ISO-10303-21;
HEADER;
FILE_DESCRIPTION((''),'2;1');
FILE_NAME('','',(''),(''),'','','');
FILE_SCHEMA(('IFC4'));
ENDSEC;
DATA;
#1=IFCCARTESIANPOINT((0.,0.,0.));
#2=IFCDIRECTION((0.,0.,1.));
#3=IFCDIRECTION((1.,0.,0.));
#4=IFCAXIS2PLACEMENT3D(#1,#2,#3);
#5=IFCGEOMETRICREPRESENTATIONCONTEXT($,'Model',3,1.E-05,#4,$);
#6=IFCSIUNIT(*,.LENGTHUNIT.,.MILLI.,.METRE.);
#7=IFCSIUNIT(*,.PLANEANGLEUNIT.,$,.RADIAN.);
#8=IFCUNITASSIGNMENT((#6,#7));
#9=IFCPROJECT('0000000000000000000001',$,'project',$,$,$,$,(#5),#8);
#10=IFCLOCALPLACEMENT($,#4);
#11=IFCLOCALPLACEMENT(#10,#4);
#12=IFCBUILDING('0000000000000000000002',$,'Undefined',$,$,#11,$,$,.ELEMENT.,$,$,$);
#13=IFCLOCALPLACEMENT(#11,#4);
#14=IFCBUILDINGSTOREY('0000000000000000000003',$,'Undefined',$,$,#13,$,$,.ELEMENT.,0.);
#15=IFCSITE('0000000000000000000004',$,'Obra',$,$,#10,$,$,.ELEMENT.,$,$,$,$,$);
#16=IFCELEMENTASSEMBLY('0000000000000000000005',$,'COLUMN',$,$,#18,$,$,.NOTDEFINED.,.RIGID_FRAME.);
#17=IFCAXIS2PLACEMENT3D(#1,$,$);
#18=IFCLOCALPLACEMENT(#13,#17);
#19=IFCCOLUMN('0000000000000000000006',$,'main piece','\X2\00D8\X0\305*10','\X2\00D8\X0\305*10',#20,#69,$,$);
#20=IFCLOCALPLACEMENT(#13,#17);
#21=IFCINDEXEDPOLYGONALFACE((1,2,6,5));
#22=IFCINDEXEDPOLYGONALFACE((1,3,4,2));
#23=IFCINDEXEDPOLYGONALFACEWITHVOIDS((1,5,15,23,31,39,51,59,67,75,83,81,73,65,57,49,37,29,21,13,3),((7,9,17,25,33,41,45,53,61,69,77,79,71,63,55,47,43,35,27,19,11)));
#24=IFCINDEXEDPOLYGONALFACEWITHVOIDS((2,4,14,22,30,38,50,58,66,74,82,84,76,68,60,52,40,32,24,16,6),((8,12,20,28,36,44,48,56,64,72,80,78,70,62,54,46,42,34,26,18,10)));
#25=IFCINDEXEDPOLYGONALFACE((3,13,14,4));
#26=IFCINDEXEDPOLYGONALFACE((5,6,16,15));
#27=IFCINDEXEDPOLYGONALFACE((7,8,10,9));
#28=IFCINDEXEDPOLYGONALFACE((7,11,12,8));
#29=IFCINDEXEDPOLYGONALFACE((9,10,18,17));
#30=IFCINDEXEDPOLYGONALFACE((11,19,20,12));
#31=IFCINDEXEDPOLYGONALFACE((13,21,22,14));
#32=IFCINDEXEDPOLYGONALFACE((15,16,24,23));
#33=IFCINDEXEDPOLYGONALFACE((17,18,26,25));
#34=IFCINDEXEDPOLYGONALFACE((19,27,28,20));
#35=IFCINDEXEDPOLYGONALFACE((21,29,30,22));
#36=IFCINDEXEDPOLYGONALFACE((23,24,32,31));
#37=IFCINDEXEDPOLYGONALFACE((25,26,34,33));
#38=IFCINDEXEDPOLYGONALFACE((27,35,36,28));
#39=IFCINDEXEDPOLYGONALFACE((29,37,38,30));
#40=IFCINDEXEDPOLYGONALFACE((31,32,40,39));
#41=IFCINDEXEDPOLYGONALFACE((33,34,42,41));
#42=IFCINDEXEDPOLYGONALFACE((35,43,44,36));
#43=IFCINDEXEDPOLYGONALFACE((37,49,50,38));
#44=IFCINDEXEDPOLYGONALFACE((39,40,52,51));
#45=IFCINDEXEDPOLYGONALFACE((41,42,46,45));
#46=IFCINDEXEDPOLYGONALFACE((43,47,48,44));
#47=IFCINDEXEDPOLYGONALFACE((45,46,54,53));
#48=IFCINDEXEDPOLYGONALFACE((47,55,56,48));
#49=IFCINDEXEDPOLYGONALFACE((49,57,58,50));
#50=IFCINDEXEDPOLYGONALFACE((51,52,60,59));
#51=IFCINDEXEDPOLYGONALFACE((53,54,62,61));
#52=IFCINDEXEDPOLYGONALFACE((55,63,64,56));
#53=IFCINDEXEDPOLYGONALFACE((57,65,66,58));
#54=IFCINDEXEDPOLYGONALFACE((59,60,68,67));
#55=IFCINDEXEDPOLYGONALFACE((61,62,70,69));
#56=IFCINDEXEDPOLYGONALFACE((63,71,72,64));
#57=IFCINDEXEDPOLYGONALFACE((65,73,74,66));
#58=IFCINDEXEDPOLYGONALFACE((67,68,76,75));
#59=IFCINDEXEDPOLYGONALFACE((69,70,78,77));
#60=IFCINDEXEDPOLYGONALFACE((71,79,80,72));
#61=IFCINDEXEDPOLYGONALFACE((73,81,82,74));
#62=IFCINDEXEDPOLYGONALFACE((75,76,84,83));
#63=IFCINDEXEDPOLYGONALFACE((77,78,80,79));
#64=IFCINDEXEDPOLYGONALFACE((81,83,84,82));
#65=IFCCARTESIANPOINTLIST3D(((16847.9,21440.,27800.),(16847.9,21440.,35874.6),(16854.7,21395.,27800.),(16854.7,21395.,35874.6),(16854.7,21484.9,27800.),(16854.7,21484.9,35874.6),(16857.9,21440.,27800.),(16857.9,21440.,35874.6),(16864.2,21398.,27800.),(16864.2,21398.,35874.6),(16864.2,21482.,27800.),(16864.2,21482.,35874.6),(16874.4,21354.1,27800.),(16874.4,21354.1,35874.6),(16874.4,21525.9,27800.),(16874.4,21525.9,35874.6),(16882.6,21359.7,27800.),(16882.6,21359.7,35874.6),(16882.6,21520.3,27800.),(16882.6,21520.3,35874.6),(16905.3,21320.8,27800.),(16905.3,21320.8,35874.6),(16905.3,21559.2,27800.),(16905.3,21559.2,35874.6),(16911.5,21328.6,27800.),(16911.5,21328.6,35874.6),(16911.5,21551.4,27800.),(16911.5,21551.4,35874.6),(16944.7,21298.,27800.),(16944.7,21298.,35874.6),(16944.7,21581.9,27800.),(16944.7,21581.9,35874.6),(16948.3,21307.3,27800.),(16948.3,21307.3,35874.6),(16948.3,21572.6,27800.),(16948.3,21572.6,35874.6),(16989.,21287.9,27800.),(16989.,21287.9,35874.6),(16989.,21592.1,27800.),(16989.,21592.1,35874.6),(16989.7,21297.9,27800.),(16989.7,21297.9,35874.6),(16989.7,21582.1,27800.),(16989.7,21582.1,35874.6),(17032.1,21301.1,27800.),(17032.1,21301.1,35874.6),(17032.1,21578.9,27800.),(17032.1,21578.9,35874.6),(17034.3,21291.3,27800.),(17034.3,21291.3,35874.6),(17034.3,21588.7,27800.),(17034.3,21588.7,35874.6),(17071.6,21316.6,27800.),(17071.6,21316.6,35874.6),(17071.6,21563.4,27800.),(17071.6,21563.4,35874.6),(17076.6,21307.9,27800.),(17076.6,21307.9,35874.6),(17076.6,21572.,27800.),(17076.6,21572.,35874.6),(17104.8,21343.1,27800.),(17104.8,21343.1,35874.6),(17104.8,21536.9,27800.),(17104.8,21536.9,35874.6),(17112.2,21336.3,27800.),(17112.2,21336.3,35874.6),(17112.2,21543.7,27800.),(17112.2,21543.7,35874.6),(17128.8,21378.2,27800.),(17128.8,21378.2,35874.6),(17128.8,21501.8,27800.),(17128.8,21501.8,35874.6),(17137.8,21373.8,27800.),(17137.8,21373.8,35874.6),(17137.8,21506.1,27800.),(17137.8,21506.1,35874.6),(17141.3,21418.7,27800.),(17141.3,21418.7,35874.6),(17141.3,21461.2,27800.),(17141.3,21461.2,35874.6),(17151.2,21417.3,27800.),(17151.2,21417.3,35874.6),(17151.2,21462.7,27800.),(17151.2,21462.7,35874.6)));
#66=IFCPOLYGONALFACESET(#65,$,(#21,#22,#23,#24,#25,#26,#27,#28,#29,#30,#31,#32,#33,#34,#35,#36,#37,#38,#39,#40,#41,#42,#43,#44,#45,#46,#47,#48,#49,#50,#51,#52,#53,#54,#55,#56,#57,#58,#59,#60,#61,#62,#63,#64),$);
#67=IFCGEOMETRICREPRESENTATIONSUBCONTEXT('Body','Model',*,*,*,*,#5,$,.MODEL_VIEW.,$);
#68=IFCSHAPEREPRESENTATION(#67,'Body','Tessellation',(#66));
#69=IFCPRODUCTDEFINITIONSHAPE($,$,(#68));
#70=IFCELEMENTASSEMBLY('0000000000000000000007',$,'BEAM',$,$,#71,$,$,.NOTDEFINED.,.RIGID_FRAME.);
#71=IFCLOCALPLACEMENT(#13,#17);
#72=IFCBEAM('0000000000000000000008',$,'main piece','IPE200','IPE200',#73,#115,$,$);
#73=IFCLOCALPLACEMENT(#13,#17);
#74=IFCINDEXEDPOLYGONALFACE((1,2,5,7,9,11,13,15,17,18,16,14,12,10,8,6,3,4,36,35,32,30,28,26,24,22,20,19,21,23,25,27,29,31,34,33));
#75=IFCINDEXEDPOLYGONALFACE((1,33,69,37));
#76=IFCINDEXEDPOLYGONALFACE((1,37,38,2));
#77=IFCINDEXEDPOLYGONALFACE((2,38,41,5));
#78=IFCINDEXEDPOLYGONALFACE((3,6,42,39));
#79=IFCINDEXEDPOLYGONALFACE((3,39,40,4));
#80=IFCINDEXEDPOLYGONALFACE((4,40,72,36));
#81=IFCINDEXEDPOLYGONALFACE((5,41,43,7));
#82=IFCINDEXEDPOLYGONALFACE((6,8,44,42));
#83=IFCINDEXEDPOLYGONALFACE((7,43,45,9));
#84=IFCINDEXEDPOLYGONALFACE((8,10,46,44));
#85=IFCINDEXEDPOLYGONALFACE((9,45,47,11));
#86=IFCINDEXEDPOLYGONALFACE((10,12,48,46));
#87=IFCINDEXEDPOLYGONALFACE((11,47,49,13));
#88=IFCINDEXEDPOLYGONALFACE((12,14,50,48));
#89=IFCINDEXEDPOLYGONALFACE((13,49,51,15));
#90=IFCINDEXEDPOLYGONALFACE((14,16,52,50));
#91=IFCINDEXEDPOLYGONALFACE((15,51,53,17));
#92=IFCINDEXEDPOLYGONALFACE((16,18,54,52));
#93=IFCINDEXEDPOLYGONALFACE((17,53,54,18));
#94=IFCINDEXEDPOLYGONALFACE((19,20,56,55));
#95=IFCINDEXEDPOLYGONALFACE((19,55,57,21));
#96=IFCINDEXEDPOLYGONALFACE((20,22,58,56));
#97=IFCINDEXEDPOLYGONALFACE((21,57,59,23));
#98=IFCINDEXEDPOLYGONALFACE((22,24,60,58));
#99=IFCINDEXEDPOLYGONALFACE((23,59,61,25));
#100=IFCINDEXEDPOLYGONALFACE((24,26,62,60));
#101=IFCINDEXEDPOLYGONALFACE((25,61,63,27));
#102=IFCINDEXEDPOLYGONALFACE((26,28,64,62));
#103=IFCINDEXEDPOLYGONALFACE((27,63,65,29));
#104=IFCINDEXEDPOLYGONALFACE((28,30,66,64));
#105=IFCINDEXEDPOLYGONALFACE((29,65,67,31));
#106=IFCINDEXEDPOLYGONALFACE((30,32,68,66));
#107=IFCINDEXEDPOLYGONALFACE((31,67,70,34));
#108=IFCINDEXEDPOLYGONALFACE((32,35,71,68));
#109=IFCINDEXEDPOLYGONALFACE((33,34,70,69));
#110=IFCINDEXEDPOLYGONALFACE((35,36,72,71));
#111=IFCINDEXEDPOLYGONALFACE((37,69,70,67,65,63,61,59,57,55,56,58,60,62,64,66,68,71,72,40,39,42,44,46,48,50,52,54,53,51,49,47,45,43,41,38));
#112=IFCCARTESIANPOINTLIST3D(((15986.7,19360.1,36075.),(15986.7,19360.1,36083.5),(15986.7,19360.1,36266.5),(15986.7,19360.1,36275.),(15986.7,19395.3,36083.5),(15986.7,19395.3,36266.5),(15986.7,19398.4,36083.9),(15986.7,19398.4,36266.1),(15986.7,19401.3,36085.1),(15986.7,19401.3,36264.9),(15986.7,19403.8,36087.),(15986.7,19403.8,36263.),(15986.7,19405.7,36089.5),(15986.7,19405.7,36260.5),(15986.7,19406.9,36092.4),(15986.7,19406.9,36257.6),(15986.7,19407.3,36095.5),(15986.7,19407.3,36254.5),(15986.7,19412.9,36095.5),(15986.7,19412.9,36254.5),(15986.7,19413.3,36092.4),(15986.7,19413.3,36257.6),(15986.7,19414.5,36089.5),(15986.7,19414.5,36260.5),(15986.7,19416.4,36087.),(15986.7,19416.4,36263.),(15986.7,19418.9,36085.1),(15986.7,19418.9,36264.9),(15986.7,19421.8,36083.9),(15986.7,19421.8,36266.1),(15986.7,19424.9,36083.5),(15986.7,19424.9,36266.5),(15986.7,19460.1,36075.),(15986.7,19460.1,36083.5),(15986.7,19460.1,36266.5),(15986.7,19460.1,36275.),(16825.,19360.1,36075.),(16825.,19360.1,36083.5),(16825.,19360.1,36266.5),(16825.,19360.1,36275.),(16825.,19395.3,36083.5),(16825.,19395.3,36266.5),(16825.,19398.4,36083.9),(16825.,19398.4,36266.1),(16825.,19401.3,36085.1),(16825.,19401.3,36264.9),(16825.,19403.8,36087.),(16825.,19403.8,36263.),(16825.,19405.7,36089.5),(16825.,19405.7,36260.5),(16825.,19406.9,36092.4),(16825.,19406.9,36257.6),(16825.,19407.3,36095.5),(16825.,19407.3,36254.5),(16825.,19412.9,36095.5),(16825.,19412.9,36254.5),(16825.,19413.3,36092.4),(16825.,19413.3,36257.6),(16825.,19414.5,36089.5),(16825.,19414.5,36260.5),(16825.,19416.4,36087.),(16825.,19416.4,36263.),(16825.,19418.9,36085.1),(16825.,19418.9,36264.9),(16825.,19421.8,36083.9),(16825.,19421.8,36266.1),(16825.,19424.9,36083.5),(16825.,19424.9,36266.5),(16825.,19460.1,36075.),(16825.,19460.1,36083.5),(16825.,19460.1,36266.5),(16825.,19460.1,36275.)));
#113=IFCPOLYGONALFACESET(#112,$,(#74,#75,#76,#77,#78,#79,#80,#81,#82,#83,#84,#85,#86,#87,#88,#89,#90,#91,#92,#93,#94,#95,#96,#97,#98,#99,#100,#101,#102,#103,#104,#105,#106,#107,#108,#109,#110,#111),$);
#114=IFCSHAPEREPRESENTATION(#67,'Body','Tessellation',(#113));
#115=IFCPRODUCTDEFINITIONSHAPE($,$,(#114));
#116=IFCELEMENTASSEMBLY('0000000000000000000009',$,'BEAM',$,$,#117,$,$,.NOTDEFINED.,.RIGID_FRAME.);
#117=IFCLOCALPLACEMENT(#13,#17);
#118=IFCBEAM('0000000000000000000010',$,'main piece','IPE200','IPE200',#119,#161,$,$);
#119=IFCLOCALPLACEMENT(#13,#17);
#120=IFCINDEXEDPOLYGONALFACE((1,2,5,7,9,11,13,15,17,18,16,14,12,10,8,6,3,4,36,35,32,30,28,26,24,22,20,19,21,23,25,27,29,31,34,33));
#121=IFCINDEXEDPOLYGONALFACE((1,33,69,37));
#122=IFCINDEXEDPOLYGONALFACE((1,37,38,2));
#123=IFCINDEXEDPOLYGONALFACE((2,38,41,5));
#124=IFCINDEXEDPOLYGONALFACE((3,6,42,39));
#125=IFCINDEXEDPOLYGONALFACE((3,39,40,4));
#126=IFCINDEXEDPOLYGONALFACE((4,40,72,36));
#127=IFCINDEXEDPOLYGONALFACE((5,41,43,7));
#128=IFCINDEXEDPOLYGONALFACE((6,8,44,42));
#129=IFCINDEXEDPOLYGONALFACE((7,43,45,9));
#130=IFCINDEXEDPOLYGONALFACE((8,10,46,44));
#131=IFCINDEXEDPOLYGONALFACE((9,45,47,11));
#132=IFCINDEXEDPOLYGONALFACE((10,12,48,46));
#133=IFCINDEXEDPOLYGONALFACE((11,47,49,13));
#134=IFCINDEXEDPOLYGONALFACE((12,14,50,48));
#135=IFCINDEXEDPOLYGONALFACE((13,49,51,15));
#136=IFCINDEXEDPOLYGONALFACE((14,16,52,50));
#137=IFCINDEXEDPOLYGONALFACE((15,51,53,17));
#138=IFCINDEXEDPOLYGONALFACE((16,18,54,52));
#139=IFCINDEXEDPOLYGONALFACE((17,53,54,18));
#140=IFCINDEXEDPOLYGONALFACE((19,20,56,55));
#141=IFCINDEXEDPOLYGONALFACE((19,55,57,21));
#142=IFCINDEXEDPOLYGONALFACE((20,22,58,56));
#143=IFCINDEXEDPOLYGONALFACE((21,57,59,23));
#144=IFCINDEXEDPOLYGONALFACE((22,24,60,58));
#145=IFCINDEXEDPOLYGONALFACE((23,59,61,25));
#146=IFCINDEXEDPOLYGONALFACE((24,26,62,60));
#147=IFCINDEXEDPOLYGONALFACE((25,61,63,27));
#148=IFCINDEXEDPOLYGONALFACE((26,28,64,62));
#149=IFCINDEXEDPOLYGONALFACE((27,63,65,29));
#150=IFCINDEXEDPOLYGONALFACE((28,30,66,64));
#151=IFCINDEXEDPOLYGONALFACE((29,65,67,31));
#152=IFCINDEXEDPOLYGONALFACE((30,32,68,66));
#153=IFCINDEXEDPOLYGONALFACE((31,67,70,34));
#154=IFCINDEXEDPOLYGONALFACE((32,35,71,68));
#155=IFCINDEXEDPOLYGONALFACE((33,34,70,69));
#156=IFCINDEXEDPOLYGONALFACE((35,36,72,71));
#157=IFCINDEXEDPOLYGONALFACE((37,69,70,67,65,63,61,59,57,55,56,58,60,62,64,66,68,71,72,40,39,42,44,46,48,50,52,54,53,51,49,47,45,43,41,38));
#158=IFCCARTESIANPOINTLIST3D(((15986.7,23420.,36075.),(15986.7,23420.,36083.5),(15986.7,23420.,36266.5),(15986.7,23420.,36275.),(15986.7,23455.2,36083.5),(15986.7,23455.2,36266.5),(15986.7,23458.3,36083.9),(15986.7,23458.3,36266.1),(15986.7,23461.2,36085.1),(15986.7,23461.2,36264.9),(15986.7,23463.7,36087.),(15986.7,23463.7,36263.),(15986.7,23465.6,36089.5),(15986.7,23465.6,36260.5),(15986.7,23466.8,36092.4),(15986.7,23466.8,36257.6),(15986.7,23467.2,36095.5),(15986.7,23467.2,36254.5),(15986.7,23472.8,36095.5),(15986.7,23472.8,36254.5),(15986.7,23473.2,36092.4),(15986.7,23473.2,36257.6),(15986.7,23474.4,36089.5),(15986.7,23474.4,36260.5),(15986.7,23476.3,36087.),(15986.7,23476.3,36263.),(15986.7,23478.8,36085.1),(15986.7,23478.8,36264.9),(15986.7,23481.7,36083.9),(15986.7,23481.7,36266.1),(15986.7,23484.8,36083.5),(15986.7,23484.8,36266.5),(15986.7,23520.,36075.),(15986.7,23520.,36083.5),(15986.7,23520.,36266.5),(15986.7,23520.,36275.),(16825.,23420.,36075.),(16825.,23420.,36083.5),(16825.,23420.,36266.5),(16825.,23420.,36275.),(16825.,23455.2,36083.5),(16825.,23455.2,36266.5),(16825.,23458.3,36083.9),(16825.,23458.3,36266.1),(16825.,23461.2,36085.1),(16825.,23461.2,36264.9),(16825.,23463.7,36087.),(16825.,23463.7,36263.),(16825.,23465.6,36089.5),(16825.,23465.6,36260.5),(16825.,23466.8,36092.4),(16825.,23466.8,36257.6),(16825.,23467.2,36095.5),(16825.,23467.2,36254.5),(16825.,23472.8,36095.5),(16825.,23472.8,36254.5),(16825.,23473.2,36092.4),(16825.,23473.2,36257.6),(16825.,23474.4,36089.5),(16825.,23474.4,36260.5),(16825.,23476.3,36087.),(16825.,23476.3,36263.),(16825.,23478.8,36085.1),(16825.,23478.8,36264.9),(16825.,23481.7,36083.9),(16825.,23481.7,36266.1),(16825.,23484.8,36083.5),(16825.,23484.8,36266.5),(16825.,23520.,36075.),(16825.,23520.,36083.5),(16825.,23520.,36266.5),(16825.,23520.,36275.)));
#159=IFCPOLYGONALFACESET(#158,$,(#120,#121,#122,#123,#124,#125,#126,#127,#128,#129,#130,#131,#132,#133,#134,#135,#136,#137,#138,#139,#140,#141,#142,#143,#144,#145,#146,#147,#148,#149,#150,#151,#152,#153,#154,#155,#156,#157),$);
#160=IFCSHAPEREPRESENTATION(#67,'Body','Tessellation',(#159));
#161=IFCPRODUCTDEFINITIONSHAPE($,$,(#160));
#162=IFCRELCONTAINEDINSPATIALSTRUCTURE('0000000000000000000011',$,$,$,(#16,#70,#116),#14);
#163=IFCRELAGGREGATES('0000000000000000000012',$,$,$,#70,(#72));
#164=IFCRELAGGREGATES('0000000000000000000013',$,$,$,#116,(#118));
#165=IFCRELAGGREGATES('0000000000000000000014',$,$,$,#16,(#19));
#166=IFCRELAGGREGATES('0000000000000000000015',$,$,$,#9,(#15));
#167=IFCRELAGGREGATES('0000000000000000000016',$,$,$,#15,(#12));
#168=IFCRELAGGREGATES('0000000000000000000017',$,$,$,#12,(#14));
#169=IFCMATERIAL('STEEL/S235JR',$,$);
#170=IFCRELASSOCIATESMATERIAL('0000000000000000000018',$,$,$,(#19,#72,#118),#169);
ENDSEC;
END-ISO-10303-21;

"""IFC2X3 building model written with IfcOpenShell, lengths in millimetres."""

from ifc_helpers import new_model, si_unit, frame, origin_with_axes, origin_2d_with_axis, place, context, subcontext, project, spatial, hollow_circle, i_section, extrude, clip, halfspace, material, element, aggregate, save


model = new_model("IFC2X3")

# Units and contexts
model_context = context("Model", 3, precision=1e-05, world=origin_with_axes())
body_context = subcontext(model_context, "Body", "Model", "MODEL_VIEW")
ifc_project = project(units=[si_unit("LENGTHUNIT", "METRE", prefix="MILLI"), si_unit("PLANEANGLEUNIT", "RADIAN")], contexts=[model_context])

# Site, building, storey
site_placement = place(None, origin_with_axes())
site = spatial("IfcSite", under=ifc_project, at=site_placement, Name="Obra", CompositionType="ELEMENT")
building_placement = place(site_placement, origin_with_axes())
building = spatial("IfcBuilding", under=site, at=building_placement, Name="Undefined", CompositionType="ELEMENT")
storey_placement = place(building_placement, origin_with_axes())
storey = spatial("IfcBuildingStorey", under=building, at=storey_placement, Name="Undefined", CompositionType="ELEMENT", Elevation=0.0)

# Element assembly, column
assembly_1_placement = place(storey_placement, origin_with_axes())
assembly_1 = element("IfcElementAssembly", 1, at=assembly_1_placement, inside=storey, Name="COLUMN", AssemblyPlace="NOTDEFINED", PredefinedType="RIGID_FRAME")
ifc_material_1 = material(Name="STEEL/S235JR")
column_placement = place(assembly_1_placement, frame((17000.4, 21440.0, 27800.0), z_axis=(0.0, 0.0, 1.0), x_axis=(0.0, 1.0, 0.0)))
column = element("IfcColumn", 2, at=column_placement, material=ifc_material_1, Name="main piece", Description="Ø305*10", ObjectType="Ø305*10", context=body_context, shape_type="Clipping", body=[
    clip(extrude(hollow_circle(Radius=152.5, WallThickness=10.0, at=origin_2d_with_axis()), frame((0.0, 0.0, 8074.6), z_axis=(0.0, 0.0, -1.0), x_axis=(0.0, 1.0, 0.0)), (0.0, 0.0, 1.0), 8074.6), halfspace(frame((-152.5, 0.0, 8074.5), z_axis=(0.000195, 0.0, -1.0), x_axis=(0.0, -1.0, 0.0)), True)),
])

# Element assemblies, beams
assembly_2_placement = place(storey_placement, origin_with_axes())
assembly_2 = element("IfcElementAssembly", 3, at=assembly_2_placement, inside=storey, Name="BEAM", AssemblyPlace="NOTDEFINED", PredefinedType="RIGID_FRAME")
beam_1_placement = place(assembly_2_placement, frame((15986.7, 19410.1, 36175.0), z_axis=(0.0, 0.0, 1.0), x_axis=(1.0, 0.0, 0.0)))
beam_1 = element("IfcBeam", 4, at=beam_1_placement, material=ifc_material_1, Name="main piece", Description="IPE200", ObjectType="IPE200", context=body_context, shape_type="SweptSolid", body=[
    extrude(i_section(OverallWidth=100.0, OverallDepth=200.0, WebThickness=5.6, FlangeThickness=8.5, FilletRadius=12.0, at=origin_2d_with_axis()), frame((838.3, 0.0, 0.0), z_axis=(-1.0, 0.0, 0.0), x_axis=(0.0, -1.0, 0.0)), (0.0, 0.0, 1.0), 838.3),
])
aggregate(assembly_2, [beam_1])
assembly_3_placement = place(storey_placement, origin_with_axes())
assembly_3 = element("IfcElementAssembly", 5, at=assembly_3_placement, inside=storey, Name="BEAM", AssemblyPlace="NOTDEFINED", PredefinedType="RIGID_FRAME")
beam_2_placement = place(assembly_3_placement, frame((15986.7, 23470.0, 36175.0), z_axis=(0.0, 0.0, 1.0), x_axis=(1.0, 0.0, 0.0)))
beam_2 = element("IfcBeam", 6, at=beam_2_placement, material=ifc_material_1, Name="main piece", Description="IPE200", ObjectType="IPE200", context=body_context, shape_type="SweptSolid", body=[
    extrude(i_section(OverallWidth=100.0, OverallDepth=200.0, WebThickness=5.6, FlangeThickness=8.5, FilletRadius=12.0, at=origin_2d_with_axis()), frame((838.3, 0.0, 0.0), z_axis=(-1.0, 0.0, 0.0), x_axis=(0.0, -1.0, 0.0)), (0.0, 0.0, 1.0), 838.3),
])
aggregate(assembly_3, [beam_2])

aggregate(assembly_1, [column])

save(model, "model.ifc")
